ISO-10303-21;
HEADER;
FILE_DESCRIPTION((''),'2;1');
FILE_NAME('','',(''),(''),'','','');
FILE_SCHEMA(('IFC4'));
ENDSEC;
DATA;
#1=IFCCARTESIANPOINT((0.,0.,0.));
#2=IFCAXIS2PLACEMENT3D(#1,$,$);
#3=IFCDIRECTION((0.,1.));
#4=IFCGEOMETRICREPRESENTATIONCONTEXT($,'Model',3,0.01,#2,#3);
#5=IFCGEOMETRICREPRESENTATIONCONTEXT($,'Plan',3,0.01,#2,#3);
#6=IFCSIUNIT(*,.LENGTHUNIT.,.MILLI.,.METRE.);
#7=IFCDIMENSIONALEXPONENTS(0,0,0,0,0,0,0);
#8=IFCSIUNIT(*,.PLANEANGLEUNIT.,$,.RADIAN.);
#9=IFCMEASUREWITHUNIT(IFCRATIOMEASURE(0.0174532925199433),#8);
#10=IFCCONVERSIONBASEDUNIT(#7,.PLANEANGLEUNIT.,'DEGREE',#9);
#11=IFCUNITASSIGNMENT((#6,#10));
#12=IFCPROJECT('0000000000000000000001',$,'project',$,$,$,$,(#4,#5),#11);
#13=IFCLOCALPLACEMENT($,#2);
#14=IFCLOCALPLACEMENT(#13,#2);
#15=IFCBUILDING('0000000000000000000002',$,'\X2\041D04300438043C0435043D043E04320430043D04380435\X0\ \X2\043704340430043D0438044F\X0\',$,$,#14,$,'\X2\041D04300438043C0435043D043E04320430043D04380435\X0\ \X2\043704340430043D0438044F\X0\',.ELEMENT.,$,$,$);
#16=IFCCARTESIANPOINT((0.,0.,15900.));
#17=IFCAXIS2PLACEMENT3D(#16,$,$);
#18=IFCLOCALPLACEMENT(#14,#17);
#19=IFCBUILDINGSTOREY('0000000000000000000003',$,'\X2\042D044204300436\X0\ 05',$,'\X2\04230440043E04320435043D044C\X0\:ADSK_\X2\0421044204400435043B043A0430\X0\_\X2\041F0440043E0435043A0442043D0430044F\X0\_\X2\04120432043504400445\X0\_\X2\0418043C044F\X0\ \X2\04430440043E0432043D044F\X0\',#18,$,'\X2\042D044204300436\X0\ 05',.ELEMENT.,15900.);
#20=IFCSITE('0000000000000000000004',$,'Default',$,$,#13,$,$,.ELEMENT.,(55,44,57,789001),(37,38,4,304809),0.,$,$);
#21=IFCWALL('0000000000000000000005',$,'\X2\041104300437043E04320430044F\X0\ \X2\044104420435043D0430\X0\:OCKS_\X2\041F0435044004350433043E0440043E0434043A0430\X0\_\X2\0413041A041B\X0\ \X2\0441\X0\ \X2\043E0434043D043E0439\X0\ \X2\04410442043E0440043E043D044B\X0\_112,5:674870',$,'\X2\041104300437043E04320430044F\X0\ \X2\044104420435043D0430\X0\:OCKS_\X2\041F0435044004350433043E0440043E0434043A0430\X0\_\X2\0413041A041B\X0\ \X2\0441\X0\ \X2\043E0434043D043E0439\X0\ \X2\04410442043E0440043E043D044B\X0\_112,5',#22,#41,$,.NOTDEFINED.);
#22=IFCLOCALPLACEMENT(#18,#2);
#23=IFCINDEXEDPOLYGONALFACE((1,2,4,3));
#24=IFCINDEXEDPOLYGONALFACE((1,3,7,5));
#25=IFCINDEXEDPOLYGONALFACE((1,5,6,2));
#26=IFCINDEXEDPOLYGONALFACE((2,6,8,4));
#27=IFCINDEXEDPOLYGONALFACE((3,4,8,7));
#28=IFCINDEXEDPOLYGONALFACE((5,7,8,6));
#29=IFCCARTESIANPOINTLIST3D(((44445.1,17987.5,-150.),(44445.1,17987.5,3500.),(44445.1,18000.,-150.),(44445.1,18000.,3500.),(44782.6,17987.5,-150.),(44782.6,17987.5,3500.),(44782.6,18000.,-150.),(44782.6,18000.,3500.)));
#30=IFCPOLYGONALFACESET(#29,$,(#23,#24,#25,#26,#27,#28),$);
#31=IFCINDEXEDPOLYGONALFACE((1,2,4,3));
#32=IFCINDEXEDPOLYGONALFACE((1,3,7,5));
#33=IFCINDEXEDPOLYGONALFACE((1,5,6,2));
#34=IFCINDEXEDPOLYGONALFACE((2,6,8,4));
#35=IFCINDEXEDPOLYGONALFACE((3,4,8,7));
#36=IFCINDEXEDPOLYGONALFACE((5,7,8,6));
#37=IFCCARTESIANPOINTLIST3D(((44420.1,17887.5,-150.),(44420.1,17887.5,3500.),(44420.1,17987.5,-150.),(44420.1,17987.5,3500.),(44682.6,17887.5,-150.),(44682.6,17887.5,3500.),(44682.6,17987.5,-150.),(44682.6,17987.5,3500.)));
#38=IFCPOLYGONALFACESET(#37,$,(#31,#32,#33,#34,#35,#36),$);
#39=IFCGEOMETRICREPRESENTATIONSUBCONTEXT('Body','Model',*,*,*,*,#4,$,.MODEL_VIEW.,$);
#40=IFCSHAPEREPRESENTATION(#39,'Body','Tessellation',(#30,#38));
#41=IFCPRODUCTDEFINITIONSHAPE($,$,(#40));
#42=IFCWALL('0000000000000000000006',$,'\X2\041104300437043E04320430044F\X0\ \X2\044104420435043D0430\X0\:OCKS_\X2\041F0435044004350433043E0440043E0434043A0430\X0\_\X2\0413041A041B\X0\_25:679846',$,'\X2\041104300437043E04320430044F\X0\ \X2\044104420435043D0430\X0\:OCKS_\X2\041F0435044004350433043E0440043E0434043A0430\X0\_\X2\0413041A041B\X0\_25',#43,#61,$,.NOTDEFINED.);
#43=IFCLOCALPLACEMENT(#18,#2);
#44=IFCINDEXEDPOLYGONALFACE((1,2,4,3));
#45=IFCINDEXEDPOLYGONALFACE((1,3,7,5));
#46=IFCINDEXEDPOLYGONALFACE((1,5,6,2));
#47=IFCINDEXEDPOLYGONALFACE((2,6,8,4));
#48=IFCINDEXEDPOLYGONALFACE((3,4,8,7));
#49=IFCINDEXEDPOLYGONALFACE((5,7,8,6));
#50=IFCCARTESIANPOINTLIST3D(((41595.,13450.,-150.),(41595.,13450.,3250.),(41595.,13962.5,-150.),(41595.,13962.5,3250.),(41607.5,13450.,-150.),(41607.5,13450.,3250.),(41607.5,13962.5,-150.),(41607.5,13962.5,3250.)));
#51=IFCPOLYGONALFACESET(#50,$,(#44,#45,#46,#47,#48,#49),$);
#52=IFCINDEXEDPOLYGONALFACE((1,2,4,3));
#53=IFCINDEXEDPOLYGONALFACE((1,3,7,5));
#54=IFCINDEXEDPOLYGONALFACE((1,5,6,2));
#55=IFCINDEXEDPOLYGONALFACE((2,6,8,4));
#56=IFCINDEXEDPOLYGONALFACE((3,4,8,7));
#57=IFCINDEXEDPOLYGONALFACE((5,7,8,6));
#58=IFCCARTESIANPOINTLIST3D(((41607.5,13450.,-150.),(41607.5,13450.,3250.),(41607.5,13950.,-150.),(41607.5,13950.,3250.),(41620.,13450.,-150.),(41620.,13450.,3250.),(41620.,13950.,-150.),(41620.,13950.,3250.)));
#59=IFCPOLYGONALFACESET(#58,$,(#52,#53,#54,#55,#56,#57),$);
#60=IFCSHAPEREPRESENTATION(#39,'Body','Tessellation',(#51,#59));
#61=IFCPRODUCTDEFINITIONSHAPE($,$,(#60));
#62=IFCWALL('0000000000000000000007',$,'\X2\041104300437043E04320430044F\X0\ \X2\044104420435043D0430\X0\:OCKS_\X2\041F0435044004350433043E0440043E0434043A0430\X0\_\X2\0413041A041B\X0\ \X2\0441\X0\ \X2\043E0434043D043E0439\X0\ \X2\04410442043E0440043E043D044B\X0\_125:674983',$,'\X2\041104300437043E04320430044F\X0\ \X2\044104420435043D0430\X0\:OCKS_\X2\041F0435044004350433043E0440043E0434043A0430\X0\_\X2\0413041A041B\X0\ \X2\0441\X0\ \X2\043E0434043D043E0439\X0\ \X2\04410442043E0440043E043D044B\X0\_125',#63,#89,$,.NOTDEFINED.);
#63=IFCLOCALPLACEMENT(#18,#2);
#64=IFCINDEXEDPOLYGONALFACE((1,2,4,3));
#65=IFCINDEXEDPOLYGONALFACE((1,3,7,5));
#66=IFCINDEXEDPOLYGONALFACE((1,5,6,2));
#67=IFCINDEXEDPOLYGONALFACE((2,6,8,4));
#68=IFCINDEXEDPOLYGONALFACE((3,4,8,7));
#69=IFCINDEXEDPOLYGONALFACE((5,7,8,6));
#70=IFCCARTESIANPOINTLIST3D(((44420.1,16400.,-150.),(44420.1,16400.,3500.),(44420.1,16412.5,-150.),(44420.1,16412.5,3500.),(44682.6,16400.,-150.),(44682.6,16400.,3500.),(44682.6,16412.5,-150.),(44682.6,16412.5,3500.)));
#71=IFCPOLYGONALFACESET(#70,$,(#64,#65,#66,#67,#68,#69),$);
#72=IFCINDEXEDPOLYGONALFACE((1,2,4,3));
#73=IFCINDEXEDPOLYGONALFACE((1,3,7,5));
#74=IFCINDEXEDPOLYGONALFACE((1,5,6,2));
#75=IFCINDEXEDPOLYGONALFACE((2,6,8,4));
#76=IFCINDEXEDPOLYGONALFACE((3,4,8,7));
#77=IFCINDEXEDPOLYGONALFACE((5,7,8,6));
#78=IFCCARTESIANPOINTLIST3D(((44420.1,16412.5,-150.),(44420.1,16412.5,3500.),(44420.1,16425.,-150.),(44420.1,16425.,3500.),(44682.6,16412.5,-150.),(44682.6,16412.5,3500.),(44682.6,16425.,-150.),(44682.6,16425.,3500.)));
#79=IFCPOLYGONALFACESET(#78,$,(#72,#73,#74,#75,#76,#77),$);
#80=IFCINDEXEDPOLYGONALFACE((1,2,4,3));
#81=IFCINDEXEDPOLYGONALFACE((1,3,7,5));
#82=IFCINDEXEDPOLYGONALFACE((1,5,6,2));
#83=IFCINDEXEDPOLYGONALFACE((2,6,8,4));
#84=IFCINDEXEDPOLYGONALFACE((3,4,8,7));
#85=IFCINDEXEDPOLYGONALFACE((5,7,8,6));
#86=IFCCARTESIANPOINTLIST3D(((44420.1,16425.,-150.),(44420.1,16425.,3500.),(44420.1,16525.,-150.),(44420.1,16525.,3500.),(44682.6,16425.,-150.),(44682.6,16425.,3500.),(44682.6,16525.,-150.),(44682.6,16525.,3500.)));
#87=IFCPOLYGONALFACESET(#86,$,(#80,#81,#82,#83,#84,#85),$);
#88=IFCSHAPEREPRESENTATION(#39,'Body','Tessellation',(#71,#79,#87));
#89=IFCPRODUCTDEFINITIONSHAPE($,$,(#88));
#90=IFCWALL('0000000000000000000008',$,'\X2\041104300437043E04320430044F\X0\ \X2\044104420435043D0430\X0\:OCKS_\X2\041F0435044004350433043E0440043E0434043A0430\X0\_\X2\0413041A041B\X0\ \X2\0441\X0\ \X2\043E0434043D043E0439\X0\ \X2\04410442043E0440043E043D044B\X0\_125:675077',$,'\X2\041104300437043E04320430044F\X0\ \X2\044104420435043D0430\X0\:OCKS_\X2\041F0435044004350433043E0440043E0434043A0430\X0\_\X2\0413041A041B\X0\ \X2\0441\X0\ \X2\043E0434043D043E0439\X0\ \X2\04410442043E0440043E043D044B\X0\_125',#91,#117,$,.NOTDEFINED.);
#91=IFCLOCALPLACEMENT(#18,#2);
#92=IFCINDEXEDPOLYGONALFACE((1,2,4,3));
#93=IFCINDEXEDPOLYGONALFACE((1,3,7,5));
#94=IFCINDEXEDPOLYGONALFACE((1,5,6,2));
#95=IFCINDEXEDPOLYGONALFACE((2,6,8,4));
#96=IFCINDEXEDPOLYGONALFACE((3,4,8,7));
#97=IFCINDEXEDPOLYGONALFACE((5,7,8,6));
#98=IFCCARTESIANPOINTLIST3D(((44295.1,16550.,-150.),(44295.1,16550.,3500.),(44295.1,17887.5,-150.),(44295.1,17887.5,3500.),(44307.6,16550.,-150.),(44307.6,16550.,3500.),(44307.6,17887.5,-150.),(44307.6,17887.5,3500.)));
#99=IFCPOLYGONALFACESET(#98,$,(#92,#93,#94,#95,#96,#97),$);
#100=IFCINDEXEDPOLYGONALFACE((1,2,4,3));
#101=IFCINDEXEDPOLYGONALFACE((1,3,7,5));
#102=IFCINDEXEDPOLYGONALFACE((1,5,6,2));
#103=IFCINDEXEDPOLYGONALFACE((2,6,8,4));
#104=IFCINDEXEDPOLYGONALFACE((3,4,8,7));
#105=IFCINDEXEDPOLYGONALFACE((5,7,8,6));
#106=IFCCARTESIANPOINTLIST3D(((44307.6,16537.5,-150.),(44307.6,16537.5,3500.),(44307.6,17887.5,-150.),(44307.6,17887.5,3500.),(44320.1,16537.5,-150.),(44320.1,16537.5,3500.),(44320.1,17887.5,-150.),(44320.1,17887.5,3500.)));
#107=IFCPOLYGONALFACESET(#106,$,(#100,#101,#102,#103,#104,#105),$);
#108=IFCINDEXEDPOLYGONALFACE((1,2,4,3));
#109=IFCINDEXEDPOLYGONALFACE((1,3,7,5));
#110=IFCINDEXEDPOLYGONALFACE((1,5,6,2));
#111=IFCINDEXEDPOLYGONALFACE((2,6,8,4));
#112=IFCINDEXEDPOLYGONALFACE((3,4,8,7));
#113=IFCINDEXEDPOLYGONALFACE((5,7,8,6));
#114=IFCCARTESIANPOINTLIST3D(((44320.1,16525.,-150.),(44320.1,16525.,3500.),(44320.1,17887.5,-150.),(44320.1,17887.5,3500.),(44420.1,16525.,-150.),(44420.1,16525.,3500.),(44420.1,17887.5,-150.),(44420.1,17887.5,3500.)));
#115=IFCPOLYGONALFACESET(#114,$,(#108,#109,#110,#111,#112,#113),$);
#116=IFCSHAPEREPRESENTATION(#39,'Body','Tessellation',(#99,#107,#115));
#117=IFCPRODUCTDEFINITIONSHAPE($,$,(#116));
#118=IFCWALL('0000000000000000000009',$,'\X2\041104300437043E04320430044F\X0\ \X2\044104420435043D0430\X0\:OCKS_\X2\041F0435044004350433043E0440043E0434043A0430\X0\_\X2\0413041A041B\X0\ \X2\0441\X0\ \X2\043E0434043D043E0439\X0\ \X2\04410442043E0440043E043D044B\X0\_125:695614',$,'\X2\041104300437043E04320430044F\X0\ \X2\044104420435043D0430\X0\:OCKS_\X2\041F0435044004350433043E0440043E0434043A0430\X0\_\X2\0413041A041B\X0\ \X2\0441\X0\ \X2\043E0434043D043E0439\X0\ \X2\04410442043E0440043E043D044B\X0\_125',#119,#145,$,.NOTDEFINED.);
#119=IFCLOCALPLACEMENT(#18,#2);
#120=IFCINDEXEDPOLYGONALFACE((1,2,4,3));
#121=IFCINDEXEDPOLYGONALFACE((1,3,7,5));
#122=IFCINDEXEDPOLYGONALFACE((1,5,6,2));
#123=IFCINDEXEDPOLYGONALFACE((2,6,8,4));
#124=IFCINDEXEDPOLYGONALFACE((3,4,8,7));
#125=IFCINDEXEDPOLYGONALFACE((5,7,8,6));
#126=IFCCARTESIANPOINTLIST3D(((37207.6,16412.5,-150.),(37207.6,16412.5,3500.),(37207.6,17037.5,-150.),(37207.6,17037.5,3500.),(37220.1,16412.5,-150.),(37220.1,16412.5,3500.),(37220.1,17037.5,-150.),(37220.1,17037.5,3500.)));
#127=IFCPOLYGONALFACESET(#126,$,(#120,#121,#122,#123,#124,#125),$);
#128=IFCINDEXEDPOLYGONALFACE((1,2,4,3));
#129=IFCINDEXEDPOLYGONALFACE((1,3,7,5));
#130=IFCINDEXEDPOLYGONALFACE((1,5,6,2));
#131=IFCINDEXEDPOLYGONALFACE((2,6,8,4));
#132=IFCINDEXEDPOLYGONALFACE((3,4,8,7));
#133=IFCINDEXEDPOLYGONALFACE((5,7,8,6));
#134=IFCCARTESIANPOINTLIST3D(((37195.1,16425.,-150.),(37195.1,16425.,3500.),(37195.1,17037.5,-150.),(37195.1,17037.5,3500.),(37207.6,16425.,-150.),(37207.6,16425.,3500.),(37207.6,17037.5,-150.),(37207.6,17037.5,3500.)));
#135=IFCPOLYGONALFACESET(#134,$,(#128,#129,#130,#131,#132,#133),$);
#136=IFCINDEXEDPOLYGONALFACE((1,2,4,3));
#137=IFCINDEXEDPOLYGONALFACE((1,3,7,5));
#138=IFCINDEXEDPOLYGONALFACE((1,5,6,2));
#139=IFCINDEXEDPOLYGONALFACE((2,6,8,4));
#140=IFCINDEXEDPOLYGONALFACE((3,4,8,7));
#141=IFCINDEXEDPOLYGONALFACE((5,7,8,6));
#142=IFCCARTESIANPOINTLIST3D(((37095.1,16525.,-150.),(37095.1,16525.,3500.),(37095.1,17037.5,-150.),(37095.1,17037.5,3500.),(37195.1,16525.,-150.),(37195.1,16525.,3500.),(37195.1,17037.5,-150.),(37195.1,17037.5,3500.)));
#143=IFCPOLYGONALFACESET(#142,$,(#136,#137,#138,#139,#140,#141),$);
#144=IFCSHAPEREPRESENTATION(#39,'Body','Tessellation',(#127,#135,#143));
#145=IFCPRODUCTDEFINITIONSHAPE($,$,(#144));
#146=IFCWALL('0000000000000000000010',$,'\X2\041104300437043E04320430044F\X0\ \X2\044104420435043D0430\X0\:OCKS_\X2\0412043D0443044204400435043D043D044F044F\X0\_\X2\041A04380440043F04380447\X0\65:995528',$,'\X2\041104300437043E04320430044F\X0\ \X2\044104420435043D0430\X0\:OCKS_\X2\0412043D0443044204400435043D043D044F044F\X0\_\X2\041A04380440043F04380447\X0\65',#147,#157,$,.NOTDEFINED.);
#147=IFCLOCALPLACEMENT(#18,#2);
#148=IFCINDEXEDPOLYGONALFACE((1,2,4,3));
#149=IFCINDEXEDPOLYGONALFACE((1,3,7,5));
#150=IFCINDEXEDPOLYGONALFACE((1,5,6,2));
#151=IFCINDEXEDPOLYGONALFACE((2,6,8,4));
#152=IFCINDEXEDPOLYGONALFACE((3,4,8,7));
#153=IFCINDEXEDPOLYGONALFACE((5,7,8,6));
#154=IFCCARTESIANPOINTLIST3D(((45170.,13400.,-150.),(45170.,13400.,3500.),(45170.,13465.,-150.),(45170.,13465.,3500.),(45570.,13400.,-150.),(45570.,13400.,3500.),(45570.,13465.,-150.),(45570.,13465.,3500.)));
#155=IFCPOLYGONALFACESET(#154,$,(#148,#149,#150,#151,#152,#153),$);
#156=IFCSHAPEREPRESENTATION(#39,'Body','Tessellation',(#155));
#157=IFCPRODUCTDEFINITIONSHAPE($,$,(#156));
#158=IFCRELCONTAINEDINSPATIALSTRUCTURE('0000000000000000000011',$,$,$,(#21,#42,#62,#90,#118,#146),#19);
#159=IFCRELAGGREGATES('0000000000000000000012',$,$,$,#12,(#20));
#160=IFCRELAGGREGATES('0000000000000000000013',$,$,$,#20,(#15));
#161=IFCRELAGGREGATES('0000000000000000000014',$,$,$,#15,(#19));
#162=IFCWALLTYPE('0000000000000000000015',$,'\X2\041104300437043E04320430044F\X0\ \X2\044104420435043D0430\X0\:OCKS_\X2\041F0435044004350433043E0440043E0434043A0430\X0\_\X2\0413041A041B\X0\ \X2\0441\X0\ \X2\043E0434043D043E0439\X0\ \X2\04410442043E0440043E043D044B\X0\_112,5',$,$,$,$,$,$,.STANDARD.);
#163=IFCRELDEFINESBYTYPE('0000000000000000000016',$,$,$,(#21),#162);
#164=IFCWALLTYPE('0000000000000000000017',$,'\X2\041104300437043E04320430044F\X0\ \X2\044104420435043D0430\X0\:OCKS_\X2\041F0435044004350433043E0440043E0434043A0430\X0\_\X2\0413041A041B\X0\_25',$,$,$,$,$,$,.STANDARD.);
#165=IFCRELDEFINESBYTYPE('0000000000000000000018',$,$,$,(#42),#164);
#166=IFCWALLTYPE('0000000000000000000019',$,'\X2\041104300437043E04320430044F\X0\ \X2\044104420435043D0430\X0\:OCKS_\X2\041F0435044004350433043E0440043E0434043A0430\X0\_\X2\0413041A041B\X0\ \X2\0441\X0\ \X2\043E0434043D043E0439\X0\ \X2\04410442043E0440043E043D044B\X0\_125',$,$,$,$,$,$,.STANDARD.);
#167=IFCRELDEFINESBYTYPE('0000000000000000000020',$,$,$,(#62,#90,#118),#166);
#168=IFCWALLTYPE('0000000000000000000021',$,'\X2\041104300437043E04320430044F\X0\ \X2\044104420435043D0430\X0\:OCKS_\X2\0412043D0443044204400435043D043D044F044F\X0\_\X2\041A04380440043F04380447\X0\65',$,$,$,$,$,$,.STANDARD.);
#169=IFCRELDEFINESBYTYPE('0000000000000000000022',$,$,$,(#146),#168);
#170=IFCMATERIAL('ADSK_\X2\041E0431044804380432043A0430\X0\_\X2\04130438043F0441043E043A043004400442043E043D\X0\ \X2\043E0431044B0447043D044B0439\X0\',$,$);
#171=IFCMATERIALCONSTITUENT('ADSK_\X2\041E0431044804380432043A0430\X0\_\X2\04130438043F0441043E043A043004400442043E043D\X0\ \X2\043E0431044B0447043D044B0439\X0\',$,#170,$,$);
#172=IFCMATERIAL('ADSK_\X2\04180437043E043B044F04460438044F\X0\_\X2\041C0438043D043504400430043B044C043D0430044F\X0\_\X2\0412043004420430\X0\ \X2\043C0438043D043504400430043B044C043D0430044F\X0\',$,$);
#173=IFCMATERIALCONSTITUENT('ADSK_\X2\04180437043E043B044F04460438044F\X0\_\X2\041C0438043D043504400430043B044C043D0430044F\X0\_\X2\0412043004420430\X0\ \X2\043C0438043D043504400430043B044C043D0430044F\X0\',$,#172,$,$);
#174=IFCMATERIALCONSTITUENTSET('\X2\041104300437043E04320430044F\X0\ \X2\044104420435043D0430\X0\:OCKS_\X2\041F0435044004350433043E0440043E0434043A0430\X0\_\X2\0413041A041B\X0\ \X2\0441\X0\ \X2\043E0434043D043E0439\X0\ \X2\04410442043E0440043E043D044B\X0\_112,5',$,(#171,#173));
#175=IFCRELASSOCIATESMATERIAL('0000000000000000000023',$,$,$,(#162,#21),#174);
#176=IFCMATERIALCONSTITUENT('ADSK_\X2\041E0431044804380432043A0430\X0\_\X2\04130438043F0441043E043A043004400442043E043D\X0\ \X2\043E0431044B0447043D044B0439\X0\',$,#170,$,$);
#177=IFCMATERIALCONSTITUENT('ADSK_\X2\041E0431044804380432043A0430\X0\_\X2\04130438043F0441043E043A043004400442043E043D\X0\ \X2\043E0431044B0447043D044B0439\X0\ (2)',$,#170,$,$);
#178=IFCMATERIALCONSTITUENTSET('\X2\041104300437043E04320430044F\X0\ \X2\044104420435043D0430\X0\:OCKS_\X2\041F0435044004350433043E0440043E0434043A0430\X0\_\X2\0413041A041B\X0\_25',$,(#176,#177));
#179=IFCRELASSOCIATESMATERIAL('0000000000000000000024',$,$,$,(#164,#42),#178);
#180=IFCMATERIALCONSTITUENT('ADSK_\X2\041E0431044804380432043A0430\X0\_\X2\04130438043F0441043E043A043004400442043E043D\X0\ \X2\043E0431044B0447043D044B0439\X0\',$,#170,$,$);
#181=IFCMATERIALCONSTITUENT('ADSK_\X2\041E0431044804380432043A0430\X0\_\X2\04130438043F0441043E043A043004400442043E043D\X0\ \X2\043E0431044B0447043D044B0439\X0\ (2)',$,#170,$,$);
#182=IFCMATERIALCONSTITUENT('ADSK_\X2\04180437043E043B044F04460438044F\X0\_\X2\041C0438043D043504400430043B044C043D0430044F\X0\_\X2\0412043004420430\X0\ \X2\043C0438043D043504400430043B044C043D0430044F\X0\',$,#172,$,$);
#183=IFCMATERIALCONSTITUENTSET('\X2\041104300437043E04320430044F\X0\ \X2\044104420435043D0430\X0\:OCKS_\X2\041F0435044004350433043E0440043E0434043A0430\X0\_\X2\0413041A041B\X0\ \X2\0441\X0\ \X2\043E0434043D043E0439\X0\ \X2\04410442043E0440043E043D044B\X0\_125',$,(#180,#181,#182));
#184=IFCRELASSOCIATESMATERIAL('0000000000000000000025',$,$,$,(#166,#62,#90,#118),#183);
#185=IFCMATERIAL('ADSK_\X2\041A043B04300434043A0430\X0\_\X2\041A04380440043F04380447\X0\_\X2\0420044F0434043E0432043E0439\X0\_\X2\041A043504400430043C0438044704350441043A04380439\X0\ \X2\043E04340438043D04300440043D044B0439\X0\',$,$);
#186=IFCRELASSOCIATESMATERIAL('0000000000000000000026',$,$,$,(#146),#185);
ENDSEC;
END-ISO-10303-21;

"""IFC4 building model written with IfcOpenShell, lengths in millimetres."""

from ifc_helpers import new_model, entity, si_unit, converted_unit, direction, frame, origin, place, context, subcontext, project, spatial, indexed_curve, outline, extrude, material, constituent, constituent_set, type_object, element, save


model = new_model("IFC4")

# Units and contexts
model_context = context("Model", 3, precision=0.01, world=origin(), true_north=direction((0.0, 1.0)))
plan_context = context("Plan", 3, precision=0.01, world=origin(), true_north=direction((0.0, 1.0)))
body_context = subcontext(model_context, "Body", "Model", "MODEL_VIEW")
ifc_project = project(units=[si_unit("LENGTHUNIT", "METRE", prefix="MILLI"), converted_unit("PLANEANGLEUNIT", "DEGREE", entity("IfcRatioMeasure", 0.0174532925199433), si_unit("PLANEANGLEUNIT", "RADIAN"), dimensions=[0, 0, 0, 0, 0, 0, 0])], contexts=[model_context, plan_context])

# Site, building, storey
site_placement = place(None, frame((0.0, 0.0, 0.0)))
site = spatial("IfcSite", under=ifc_project, at=site_placement, Name="Default", CompositionType="ELEMENT", RefLatitude=(55, 44, 57, 789001), RefLongitude=(37, 38, 4, 304809), RefElevation=0.0)
building_placement = place(site_placement, origin())
building = spatial("IfcBuilding", under=site, at=building_placement, Name="Наименование здания", LongName="Наименование здания", CompositionType="ELEMENT")
storey_placement = place(building_placement, frame((0.0, 0.0, 15900.0)))
storey = spatial("IfcBuildingStorey", under=building, at=storey_placement, Name="Этаж 05", ObjectType="Уровень:ADSK_Стрелка_Проектная_Вверх_Имя уровня", LongName="Этаж 05", CompositionType="ELEMENT", Elevation=15900.0)

# Shared definitions
ifc_material_1 = material(Name="ADSK_Обшивка_Гипсокартон обычный")
ifc_material_2 = material(Name="ADSK_Изоляция_Минеральная_Вата минеральная")

# Walls
ifc_constituent_1 = constituent(ifc_material_1, Name="ADSK_Обшивка_Гипсокартон обычный")
ifc_constituent_2 = constituent(ifc_material_2, Name="ADSK_Изоляция_Минеральная_Вата минеральная")
ifc_constituent_set_1 = constituent_set(constituents=[ifc_constituent_1, ifc_constituent_2], Name="Базовая стена:OCKS_Перегородка_ГКЛ с одной стороны_112,5")
wall_type_1 = type_object("IfcWallType", Name="Базовая стена:OCKS_Перегородка_ГКЛ с одной стороны_112,5", PredefinedType="STANDARD", material=ifc_constituent_set_1)
wall_1_placement = place(storey_placement, frame((44682.6, 17943.8, -150.0), z_axis=(0.0, 0.0, 1.0), x_axis=(-1.0, 0.0, 0.0)))
element("IfcWall", 1, at=wall_1_placement, inside=storey, type_object=wall_type_1, material=ifc_constituent_set_1, Name="Базовая стена:OCKS_Перегородка_ГКЛ с одной стороны_112,5:674870", ObjectType="Базовая стена:OCKS_Перегородка_ГКЛ с одной стороны_112,5", PredefinedType="NOTDEFINED", context=body_context, shape_type="SweptSolid", body=[
    extrude(outline(indexed_curve([(-6.2, -168.7), (6.3, -168.7), (6.3, 168.7), (-6.2, 168.7), (-6.2, -168.7)], self_intersect=False)), frame((68.7, -50.0, 0.0), z_axis=(0.0, 0.0, 1.0), x_axis=(0.0, 1.0, 0.0)), (0.0, 0.0, 1.0), 3650.0),
    extrude(outline(indexed_curve([(-50.0, -131.2), (50.0, -131.2), (50.0, 131.2), (-50.0, 131.2), (-50.0, -131.2)], self_intersect=False)), frame((131.2, 6.2, 0.0), z_axis=(0.0, 0.0, 1.0), x_axis=(0.0, -1.0, 0.0)), (0.0, 0.0, 1.0), 3650.0),
])
ifc_material_3 = material(Name="ADSK_Кладка_Кирпич_Рядовой_Керамический одинарный")
ifc_constituent_3 = constituent(ifc_material_1, Name="ADSK_Обшивка_Гипсокартон обычный")
ifc_constituent_4 = constituent(ifc_material_1, Name="ADSK_Обшивка_Гипсокартон обычный (2)")
ifc_constituent_set_2 = constituent_set(constituents=[ifc_constituent_3, ifc_constituent_4], Name="Базовая стена:OCKS_Перегородка_ГКЛ_25")
wall_type_2 = type_object("IfcWallType", Name="Базовая стена:OCKS_Перегородка_ГКЛ_25", PredefinedType="STANDARD", material=ifc_constituent_set_2)
wall_2_placement = place(storey_placement, frame((41607.5, 13950.0, -150.0), z_axis=(0.0, 0.0, 1.0), x_axis=(0.0, -1.0, 0.0)))
element("IfcWall", 2, at=wall_2_placement, inside=storey, type_object=wall_type_2, material=ifc_constituent_set_2, Name="Базовая стена:OCKS_Перегородка_ГКЛ_25:679846", ObjectType="Базовая стена:OCKS_Перегородка_ГКЛ_25", PredefinedType="NOTDEFINED", context=body_context, shape_type="SweptSolid", body=[
    extrude(outline(indexed_curve([(-6.2, -256.3), (6.3, -256.3), (6.2, 256.3), (-6.3, 256.3), (-6.2, -256.3)], self_intersect=False)), frame((243.8, -6.3, 0.0), z_axis=(0.0, 0.0, 1.0), x_axis=(0.0, 1.0, 0.0)), (0.0, 0.0, 1.0), 3400.0),
    extrude(outline(indexed_curve([(-6.3, -250.0), (6.2, -250.0), (6.2, 250.0), (-6.3, 250.0), (-6.3, -250.0)], self_intersect=False)), frame((250.0, 6.2, 0.0), z_axis=(0.0, 0.0, 1.0), x_axis=(0.0, -1.0, 0.0)), (0.0, 0.0, 1.0), 3400.0),
])
ifc_constituent_5 = constituent(ifc_material_1, Name="ADSK_Обшивка_Гипсокартон обычный")
ifc_constituent_6 = constituent(ifc_material_1, Name="ADSK_Обшивка_Гипсокартон обычный (2)")
ifc_constituent_7 = constituent(ifc_material_2, Name="ADSK_Изоляция_Минеральная_Вата минеральная")
ifc_constituent_set_3 = constituent_set(constituents=[ifc_constituent_5, ifc_constituent_6, ifc_constituent_7], Name="Базовая стена:OCKS_Перегородка_ГКЛ с одной стороны_125")
wall_type_3 = type_object("IfcWallType", Name="Базовая стена:OCKS_Перегородка_ГКЛ с одной стороны_125", PredefinedType="STANDARD", material=ifc_constituent_set_3)
wall_3_placement = place(storey_placement, frame((44420.1, 16462.5, -150.0)))
element("IfcWall", 3, at=wall_3_placement, inside=storey, type_object=wall_type_3, material=ifc_constituent_set_3, Name="Базовая стена:OCKS_Перегородка_ГКЛ с одной стороны_125:674983", ObjectType="Базовая стена:OCKS_Перегородка_ГКЛ с одной стороны_125", PredefinedType="NOTDEFINED", context=body_context, shape_type="SweptSolid", body=[
    extrude(outline(indexed_curve([(-6.2, -131.2), (6.3, -131.2), (6.3, 131.2), (-6.2, 131.2), (-6.2, -131.2)], self_intersect=False)), frame((131.2, -56.3, 0.0), z_axis=(0.0, 0.0, 1.0), x_axis=(0.0, 1.0, 0.0)), (0.0, 0.0, 1.0), 3650.0),
    extrude(outline(indexed_curve([(-131.2, -6.2), (131.2, -6.2), (131.2, 6.3), (-131.2, 6.3), (-131.2, -6.2)], self_intersect=False)), frame((131.2, -43.8, 0.0)), (0.0, 0.0, 1.0), 3650.0),
    extrude(outline(indexed_curve([(-50.0, -131.2), (50.0, -131.2), (50.0, 131.2), (-50.0, 131.2), (-50.0, -131.2)], self_intersect=False)), frame((131.2, 12.5, 0.0), z_axis=(0.0, 0.0, 1.0), x_axis=(0.0, -1.0, 0.0)), (0.0, 0.0, 1.0), 3650.0),
])
wall_4_placement = place(storey_placement, frame((44357.6, 16550.0, -150.0), z_axis=(0.0, 0.0, 1.0), x_axis=(0.0, 1.0, 0.0)))
element("IfcWall", 4, at=wall_4_placement, inside=storey, type_object=wall_type_3, material=ifc_constituent_set_3, Name="Базовая стена:OCKS_Перегородка_ГКЛ с одной стороны_125:675077", ObjectType="Базовая стена:OCKS_Перегородка_ГКЛ с одной стороны_125", PredefinedType="NOTDEFINED", context=body_context, shape_type="SweptSolid", body=[
    extrude(outline(indexed_curve([(-6.3, -668.8), (6.3, -668.8), (6.3, 668.8), (-6.3, 668.8), (-6.3, -668.8)], self_intersect=False)), frame((668.8, 56.3, 0.0), z_axis=(0.0, 0.0, 1.0), x_axis=(0.0, -1.0, 0.0)), (0.0, 0.0, 1.0), 3650.0),
    extrude(outline(indexed_curve([(-675.0, -6.2), (675.0, -6.2), (675.0, 6.3), (-675.0, 6.3), (-675.0, -6.2)], self_intersect=False)), frame((662.5, 43.7, 0.0)), (0.0, 0.0, 1.0), 3650.0),
    extrude(outline(indexed_curve([(-50.0, -681.3), (50.0, -681.3), (50.0, 681.3), (-50.0, 681.3), (-50.0, -681.3)], self_intersect=False)), frame((656.3, -12.5, 0.0), z_axis=(0.0, 0.0, 1.0), x_axis=(0.0, 1.0, 0.0)), (0.0, 0.0, 1.0), 3650.0),
])
wall_5_placement = place(storey_placement, frame((37157.6, 16525.0, -150.0), z_axis=(0.0, 0.0, 1.0), x_axis=(0.0, 1.0, 0.0)))
element("IfcWall", 5, at=wall_5_placement, inside=storey, type_object=wall_type_3, material=ifc_constituent_set_3, Name="Базовая стена:OCKS_Перегородка_ГКЛ с одной стороны_125:695614", ObjectType="Базовая стена:OCKS_Перегородка_ГКЛ с одной стороны_125", PredefinedType="NOTDEFINED", context=body_context, shape_type="SweptSolid", body=[
    extrude(outline(indexed_curve([(-6.2, -312.5), (6.3, -312.5), (6.2, 312.5), (-6.3, 312.5), (-6.2, -312.5)], self_intersect=False)), frame((200.0, -56.3, 0.0), z_axis=(0.0, 0.0, 1.0), x_axis=(0.0, 1.0, 0.0)), (0.0, 0.0, 1.0), 3650.0),
    extrude(outline(indexed_curve([(-306.2, -6.3), (306.2, -6.3), (306.2, 6.3), (-306.2, 6.3), (-306.2, -6.3)], self_intersect=False)), frame((206.2, -43.8, 0.0)), (0.0, 0.0, 1.0), 3650.0),
    extrude(outline(indexed_curve([(-50.0, -256.2), (50.0, -256.2), (50.0, 256.2), (-50.0, 256.2), (-50.0, -256.2)], self_intersect=False)), frame((256.2, 12.5, 0.0), z_axis=(0.0, 0.0, 1.0), x_axis=(0.0, -1.0, 0.0)), (0.0, 0.0, 1.0), 3650.0),
])
wall_type_4 = type_object("IfcWallType", Name="Базовая стена:OCKS_Внутренняя_Кирпич65", PredefinedType="STANDARD")
wall_6_placement = place(storey_placement, frame((45570.0, 13432.5, -150.0), z_axis=(0.0, 0.0, 1.0), x_axis=(-1.0, 0.0, 0.0)))
element("IfcWall", 6, at=wall_6_placement, inside=storey, type_object=wall_type_4, material=ifc_material_3, Name="Базовая стена:OCKS_Внутренняя_Кирпич65:995528", ObjectType="Базовая стена:OCKS_Внутренняя_Кирпич65", PredefinedType="NOTDEFINED", context=body_context, shape_type="SweptSolid", body=[
    extrude(outline(indexed_curve([(400.0, 32.5), (0.0, 32.5), (0.0, -32.5), (400.0, -32.5), (400.0, 32.5)], self_intersect=False)), origin(), (0.0, 0.0, 1.0), 3650.0),
])

save(model, "model.ifc")
